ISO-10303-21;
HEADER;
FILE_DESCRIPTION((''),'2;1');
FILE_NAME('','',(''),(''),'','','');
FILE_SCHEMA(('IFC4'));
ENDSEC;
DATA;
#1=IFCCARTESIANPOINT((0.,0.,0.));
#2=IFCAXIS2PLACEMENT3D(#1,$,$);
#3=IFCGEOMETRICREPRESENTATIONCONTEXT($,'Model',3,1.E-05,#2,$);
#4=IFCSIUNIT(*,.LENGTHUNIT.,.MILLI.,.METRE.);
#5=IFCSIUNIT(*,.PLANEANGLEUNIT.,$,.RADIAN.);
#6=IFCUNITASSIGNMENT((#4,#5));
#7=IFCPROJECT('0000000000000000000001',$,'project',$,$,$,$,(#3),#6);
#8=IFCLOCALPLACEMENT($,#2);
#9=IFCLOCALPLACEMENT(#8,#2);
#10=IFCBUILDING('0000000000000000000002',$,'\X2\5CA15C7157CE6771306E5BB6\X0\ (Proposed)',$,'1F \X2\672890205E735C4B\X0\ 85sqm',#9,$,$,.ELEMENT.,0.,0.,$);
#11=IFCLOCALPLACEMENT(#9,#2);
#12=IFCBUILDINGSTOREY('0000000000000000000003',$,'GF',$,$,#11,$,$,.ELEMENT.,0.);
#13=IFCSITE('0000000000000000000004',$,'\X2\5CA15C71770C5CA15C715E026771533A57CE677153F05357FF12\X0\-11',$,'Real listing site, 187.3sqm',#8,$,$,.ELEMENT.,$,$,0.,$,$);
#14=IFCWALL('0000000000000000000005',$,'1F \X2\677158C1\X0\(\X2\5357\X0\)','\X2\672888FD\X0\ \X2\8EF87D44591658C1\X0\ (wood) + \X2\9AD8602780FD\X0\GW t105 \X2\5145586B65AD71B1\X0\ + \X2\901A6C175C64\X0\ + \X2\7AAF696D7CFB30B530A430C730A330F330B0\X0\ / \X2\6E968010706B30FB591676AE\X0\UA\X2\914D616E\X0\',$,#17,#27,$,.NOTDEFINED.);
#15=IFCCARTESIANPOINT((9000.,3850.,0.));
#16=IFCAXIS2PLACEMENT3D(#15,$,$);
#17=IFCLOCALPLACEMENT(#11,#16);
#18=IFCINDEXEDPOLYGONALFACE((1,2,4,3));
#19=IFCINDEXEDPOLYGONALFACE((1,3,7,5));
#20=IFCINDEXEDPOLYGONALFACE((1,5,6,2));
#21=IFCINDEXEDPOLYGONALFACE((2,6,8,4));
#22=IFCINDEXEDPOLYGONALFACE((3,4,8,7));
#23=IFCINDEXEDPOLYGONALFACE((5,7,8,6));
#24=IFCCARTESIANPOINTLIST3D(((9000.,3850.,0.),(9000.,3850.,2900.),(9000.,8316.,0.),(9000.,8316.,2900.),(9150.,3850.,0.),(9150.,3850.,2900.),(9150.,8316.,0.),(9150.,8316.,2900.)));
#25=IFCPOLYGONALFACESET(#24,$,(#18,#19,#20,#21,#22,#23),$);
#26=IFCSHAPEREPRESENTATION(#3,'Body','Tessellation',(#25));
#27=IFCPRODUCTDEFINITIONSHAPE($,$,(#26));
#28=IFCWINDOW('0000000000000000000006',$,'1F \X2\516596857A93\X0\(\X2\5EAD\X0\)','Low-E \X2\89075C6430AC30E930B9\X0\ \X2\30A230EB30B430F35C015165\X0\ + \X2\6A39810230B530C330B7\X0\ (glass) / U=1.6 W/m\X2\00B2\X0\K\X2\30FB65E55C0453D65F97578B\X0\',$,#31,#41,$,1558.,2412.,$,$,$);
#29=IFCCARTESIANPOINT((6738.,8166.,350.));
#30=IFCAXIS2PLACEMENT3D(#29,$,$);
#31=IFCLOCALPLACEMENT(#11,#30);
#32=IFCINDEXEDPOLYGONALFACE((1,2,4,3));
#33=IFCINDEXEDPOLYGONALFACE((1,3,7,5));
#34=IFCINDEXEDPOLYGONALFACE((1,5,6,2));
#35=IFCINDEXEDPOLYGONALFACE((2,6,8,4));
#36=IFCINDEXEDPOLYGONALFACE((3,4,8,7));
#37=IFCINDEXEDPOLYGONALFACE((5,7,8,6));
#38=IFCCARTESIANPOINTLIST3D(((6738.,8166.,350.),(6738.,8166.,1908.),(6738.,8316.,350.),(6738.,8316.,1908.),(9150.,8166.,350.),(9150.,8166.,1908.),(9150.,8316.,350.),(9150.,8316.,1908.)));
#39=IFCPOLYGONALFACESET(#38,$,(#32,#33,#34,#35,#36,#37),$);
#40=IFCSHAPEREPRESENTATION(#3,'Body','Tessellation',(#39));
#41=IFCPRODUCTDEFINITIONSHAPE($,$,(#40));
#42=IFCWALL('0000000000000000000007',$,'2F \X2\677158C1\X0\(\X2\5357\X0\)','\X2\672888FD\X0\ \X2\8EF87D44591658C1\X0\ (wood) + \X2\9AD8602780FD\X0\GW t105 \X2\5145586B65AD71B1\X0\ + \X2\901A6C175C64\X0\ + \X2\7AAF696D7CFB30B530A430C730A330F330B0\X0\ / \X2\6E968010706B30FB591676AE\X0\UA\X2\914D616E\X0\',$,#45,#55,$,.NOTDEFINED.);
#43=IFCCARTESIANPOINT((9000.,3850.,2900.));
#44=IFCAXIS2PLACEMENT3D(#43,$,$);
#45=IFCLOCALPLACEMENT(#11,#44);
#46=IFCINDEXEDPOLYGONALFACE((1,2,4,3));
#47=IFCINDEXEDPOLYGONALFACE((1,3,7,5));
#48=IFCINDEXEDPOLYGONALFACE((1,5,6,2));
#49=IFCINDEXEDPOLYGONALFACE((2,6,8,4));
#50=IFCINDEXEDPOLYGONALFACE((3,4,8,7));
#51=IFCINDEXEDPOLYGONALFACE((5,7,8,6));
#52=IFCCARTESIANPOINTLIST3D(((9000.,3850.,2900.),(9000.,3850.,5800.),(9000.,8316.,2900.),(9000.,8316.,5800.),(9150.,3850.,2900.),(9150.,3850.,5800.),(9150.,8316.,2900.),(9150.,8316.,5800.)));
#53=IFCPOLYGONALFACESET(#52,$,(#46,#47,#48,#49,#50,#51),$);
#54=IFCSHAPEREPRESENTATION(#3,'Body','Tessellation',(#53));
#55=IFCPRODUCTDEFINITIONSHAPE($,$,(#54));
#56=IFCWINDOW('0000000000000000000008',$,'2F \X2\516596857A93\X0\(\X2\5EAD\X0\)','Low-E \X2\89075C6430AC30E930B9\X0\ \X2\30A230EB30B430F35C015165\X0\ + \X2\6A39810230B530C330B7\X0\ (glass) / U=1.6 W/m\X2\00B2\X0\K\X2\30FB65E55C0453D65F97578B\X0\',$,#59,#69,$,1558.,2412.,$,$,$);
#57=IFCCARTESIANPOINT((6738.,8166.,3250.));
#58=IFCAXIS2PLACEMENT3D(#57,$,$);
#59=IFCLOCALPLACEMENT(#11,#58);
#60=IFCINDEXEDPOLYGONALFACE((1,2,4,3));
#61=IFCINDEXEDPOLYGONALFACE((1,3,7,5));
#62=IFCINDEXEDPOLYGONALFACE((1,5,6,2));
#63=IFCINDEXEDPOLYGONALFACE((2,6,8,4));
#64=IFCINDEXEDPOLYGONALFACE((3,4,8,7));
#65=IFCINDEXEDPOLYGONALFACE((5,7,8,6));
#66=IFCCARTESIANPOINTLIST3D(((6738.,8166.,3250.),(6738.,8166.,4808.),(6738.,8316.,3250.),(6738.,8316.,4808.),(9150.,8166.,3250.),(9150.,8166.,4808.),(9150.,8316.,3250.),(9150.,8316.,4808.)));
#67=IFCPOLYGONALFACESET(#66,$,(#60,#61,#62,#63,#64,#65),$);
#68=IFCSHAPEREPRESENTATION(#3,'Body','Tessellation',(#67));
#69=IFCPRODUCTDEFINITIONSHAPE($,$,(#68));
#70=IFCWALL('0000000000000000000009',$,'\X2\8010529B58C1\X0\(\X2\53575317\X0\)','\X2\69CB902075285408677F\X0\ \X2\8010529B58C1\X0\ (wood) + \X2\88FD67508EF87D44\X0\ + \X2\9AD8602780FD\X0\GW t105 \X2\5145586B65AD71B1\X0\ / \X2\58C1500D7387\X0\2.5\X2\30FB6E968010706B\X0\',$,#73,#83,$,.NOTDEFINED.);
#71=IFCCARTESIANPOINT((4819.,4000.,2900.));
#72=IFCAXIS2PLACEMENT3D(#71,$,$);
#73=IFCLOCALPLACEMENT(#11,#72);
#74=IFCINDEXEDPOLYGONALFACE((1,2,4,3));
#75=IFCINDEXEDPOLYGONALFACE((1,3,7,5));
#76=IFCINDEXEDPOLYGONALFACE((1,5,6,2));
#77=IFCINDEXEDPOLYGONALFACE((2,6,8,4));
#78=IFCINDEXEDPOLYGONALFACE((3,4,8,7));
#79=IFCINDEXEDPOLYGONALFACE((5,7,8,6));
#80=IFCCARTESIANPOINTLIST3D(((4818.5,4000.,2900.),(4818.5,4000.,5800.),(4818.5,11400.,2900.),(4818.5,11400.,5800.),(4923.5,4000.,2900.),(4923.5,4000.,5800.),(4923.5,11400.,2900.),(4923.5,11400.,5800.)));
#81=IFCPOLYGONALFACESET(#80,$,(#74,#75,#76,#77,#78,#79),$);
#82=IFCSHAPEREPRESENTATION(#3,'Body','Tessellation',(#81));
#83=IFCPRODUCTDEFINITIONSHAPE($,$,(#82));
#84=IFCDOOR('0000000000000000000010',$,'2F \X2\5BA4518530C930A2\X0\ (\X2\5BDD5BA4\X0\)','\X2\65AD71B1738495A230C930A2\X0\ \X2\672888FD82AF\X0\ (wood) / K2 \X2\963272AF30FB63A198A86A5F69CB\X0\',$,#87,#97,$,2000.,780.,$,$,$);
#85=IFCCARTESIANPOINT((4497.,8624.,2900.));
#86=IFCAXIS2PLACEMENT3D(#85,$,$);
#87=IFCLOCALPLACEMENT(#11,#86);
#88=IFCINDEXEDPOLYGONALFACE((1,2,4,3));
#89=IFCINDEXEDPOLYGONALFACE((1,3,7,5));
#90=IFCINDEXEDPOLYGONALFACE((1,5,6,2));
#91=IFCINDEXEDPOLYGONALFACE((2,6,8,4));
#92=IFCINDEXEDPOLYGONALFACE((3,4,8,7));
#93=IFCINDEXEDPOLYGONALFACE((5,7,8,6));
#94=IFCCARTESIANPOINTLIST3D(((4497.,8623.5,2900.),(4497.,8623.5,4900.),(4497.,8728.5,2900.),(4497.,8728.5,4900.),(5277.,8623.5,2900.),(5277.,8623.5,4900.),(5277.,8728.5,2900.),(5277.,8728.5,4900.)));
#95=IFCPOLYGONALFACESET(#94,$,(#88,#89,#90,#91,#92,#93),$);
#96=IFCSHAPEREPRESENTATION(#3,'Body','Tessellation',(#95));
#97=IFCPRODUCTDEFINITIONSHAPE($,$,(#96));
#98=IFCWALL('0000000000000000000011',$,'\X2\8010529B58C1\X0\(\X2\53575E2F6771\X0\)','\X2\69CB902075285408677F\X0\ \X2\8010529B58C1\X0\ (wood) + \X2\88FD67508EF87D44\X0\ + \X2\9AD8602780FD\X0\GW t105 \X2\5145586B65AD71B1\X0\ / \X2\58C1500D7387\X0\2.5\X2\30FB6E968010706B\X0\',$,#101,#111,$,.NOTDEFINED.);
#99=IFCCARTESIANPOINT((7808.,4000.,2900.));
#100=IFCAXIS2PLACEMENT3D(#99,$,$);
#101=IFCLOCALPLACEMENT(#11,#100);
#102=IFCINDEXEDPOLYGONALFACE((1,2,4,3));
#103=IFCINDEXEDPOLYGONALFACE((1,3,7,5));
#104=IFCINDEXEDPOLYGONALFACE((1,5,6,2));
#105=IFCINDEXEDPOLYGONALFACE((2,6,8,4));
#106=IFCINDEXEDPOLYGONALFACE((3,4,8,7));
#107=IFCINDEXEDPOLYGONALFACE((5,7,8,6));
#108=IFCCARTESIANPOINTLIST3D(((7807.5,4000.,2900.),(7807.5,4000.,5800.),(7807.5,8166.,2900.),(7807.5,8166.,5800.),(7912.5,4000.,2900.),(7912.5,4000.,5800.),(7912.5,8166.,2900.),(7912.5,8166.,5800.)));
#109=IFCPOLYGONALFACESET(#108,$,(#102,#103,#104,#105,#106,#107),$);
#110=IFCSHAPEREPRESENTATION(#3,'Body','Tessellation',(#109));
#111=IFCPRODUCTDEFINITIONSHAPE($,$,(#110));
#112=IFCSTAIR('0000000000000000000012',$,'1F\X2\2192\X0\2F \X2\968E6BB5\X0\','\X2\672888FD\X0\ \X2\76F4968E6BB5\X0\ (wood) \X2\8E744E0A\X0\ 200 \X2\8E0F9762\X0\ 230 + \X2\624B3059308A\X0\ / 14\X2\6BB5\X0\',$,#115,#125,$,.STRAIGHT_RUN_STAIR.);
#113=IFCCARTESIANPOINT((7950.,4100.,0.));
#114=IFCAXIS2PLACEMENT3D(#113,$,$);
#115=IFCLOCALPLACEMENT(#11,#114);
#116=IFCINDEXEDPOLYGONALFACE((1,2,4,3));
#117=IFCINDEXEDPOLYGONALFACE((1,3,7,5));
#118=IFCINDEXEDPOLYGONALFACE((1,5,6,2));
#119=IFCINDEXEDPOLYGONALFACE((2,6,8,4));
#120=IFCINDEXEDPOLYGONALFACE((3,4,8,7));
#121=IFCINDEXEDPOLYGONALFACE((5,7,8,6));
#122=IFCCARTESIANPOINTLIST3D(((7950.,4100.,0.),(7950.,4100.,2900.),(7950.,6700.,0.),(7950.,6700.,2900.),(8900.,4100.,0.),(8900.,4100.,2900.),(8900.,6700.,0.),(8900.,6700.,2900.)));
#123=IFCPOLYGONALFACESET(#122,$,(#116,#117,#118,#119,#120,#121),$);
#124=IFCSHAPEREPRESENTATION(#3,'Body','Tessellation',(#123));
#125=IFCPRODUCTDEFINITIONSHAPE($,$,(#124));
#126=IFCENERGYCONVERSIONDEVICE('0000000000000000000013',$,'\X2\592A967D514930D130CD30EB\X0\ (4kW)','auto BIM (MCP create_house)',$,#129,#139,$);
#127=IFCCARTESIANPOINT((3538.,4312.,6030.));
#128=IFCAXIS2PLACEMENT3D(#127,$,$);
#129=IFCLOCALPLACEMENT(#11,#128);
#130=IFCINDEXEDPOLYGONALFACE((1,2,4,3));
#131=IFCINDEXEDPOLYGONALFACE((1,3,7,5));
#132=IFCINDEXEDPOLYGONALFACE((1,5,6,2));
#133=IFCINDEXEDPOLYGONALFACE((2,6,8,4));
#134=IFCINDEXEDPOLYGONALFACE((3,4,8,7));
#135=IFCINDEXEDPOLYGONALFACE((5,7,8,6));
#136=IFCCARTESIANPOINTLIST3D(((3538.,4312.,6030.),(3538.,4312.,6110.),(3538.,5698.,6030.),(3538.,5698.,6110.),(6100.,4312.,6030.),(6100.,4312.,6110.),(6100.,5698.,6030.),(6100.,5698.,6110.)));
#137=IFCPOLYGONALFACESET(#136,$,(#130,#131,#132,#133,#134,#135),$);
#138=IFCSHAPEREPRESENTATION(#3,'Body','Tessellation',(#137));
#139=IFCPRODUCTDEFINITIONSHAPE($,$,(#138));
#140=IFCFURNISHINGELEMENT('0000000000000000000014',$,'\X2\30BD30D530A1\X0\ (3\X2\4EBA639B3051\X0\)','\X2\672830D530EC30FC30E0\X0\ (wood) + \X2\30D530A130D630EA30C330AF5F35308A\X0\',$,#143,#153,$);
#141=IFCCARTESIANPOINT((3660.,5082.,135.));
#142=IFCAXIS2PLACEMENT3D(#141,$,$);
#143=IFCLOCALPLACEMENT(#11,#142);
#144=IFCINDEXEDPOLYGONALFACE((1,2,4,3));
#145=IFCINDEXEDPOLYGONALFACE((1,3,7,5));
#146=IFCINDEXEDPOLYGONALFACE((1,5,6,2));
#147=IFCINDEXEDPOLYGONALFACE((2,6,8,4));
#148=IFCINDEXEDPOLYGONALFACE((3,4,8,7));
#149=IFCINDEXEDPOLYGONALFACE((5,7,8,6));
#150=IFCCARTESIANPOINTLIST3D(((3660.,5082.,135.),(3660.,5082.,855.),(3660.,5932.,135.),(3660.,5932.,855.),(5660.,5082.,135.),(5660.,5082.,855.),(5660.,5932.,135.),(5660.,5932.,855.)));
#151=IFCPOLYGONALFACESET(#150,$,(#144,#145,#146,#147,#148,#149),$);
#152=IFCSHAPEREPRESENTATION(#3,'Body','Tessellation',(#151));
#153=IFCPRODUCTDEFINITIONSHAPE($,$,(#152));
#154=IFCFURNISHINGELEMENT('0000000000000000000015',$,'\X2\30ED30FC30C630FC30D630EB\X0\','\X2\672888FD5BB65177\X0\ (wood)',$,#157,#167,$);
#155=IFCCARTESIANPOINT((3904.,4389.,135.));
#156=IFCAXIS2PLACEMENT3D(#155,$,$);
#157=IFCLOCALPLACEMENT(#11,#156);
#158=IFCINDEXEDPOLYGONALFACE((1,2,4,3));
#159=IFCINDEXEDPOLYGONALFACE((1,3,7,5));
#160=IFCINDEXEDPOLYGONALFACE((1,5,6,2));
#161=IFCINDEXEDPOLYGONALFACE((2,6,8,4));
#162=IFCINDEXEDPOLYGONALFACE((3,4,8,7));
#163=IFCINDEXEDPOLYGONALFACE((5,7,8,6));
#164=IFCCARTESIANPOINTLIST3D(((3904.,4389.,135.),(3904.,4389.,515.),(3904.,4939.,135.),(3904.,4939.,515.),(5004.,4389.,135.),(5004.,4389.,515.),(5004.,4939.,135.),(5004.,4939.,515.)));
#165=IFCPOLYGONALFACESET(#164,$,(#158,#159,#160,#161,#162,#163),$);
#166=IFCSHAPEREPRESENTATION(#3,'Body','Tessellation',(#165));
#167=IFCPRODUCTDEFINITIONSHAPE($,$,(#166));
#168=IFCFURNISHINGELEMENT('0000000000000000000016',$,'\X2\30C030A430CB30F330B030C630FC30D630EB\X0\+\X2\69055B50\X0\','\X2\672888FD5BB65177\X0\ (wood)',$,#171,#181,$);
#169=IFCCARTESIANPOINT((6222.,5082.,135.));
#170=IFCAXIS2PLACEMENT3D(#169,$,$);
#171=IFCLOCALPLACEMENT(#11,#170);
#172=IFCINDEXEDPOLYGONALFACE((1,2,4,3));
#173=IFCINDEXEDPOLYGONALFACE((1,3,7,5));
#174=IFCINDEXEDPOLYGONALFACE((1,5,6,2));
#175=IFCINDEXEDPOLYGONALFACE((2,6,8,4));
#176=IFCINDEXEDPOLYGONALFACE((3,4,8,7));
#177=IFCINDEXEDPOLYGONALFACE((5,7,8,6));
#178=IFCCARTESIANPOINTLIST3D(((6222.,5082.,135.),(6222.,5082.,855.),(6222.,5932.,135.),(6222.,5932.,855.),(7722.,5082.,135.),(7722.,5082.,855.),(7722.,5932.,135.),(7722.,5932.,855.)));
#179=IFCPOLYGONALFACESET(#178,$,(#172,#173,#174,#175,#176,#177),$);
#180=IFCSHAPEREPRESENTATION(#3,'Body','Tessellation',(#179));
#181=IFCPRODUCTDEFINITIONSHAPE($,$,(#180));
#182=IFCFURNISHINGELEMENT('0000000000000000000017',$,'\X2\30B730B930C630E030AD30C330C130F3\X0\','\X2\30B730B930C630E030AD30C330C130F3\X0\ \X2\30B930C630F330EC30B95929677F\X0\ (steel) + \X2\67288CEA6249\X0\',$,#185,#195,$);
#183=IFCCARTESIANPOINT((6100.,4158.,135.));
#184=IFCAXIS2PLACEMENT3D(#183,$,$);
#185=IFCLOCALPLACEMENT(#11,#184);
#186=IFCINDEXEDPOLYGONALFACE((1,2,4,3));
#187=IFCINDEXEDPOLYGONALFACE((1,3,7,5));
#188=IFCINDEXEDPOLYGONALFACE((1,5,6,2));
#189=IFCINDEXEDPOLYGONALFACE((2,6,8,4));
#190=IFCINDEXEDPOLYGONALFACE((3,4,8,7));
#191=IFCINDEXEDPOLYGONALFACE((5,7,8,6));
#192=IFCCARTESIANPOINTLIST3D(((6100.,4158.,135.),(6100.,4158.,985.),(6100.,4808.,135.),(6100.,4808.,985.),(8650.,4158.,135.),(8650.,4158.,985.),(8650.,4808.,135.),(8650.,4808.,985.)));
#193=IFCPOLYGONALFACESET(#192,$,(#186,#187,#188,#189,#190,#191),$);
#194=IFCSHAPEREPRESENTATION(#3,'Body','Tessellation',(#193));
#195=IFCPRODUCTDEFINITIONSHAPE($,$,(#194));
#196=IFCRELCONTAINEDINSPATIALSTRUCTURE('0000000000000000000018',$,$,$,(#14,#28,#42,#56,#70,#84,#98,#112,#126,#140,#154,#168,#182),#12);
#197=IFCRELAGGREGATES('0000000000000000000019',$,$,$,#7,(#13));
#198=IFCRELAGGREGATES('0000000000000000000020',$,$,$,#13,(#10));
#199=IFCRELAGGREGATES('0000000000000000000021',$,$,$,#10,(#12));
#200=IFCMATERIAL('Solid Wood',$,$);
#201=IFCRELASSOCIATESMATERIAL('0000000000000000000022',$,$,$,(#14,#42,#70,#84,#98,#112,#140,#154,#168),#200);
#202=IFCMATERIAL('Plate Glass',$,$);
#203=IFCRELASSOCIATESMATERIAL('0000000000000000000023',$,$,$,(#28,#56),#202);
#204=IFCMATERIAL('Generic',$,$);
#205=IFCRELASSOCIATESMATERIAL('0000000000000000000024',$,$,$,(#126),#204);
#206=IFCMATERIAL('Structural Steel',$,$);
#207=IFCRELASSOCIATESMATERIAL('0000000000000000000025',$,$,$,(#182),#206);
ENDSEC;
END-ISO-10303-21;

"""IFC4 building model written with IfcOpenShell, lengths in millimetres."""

from ifc_helpers import new_model, si_unit, frame, frame_2d, origin, place, context, project, spatial, rectangle, extrude, material, element, fill, save


model = new_model("IFC4")

# Units and contexts
model_context = context("Model", 3, precision=1e-05, world=origin())
ifc_project = project(units=[si_unit("LENGTHUNIT", "METRE", prefix="MILLI"), si_unit("PLANEANGLEUNIT", "RADIAN")], contexts=[model_context])

# Site, building, storey
site_placement = place(None, origin())
site = spatial("IfcSite", under=ifc_project, at=site_placement, Name="岡山県岡山市東区城東台南２-11", ObjectType="Real listing site, 187.3sqm", CompositionType="ELEMENT", RefElevation=0.0)
building_placement = place(site_placement, origin())
building = spatial("IfcBuilding", under=site, at=building_placement, Name="岡山城東の家 (Proposed)", ObjectType="1F 木造平屋 85sqm", CompositionType="ELEMENT", ElevationOfRefHeight=0.0, ElevationOfTerrain=0.0)
storey_placement = place(building_placement, origin())
storey = spatial("IfcBuildingStorey", under=building, at=storey_placement, Name="GF", CompositionType="ELEMENT", Elevation=0.0)

# Wall, opening, window
ifc_material_1 = material(Name="Solid Wood")
wall_1_placement = place(storey_placement, frame((9000.0, 3850.0, 0.0)))
wall_1 = element("IfcWall", 1, at=wall_1_placement, inside=storey, material=ifc_material_1, Name="1F 東壁(南)", Description="木製 軸組外壁 (wood) + 高性能GW t105 充填断熱 + 通気層 + 窯業系サイディング / 準耐火・外皮UA配慮", PredefinedType="NOTDEFINED", context=model_context, shape_type="SweptSolid", body=[
    extrude(rectangle(XDim=150.0, YDim=4466.0, at=frame_2d((75.0, 2233.0))), frame((9000.0, 3850.0, 0.0)), (0.0, 0.0, 1.0), 2900.0),
])
opening_1_placement = place(storey_placement, frame((6738.0, 8166.0, 350.0)))
opening_1 = element("IfcOpeningElement", 2, at=opening_1_placement, cuts=wall_1, PredefinedType="NOTDEFINED", context=model_context, shape_type="SweptSolid", body=[
    extrude(rectangle(XDim=2412.0, YDim=150.0, at=frame_2d((1206.0, 75.0))), frame((6738.0, 8166.0, 350.0)), (0.0, 0.0, 1.0), 1558.0),
])
ifc_material_2 = material(Name="Plate Glass")
window_1_placement = place(storey_placement, frame((6738.0, 8166.0, 350.0)))
window_1 = element("IfcWindow", 3, at=window_1_placement, inside=storey, material=ifc_material_2, Name="1F 入隅窓(庭)", Description="Low-E 複層ガラス アルゴン封入 + 樹脂サッシ (glass) / U=1.6 W/m²K・日射取得型", OverallHeight=1558.0, OverallWidth=2412.0, context=model_context, shape_type="SweptSolid", body=[
    extrude(rectangle(XDim=2412.0, YDim=150.0, at=frame_2d((1206.0, 75.0))), frame((6738.0, 8166.0, 350.0)), (0.0, 0.0, 1.0), 1558.0),
])
fill(opening_1, window_1)

# Wall, opening, window
wall_2_placement = place(storey_placement, frame((9000.0, 3850.0, 2900.0)))
wall_2 = element("IfcWall", 4, at=wall_2_placement, inside=storey, material=ifc_material_1, Name="2F 東壁(南)", Description="木製 軸組外壁 (wood) + 高性能GW t105 充填断熱 + 通気層 + 窯業系サイディング / 準耐火・外皮UA配慮", PredefinedType="NOTDEFINED", context=model_context, shape_type="SweptSolid", body=[
    extrude(rectangle(XDim=150.0, YDim=4466.0, at=frame_2d((75.0, 2233.0))), frame((9000.0, 3850.0, 2900.0)), (0.0, 0.0, 1.0), 2900.0),
])
opening_2_placement = place(storey_placement, frame((6738.0, 8166.0, 3250.0)))
opening_2 = element("IfcOpeningElement", 5, at=opening_2_placement, cuts=wall_2, PredefinedType="NOTDEFINED", context=model_context, shape_type="SweptSolid", body=[
    extrude(rectangle(XDim=2412.0, YDim=150.0, at=frame_2d((1206.0, 75.0))), frame((6738.0, 8166.0, 3250.0)), (0.0, 0.0, 1.0), 1558.0),
])
window_2_placement = place(storey_placement, frame((6738.0, 8166.0, 3250.0)))
window_2 = element("IfcWindow", 6, at=window_2_placement, inside=storey, material=ifc_material_2, Name="2F 入隅窓(庭)", Description="Low-E 複層ガラス アルゴン封入 + 樹脂サッシ (glass) / U=1.6 W/m²K・日射取得型", OverallHeight=1558.0, OverallWidth=2412.0, context=model_context, shape_type="SweptSolid", body=[
    extrude(rectangle(XDim=2412.0, YDim=150.0, at=frame_2d((1206.0, 75.0))), frame((6738.0, 8166.0, 3250.0)), (0.0, 0.0, 1.0), 1558.0),
])
fill(opening_2, window_2)

# Wall, opening, door
wall_3_placement = place(storey_placement, frame((4819.0, 4000.0, 2900.0)))
wall_3 = element("IfcWall", 7, at=wall_3_placement, inside=storey, material=ifc_material_1, Name="耐力壁(南北)", Description="構造用合板 耐力壁 (wood) + 製材軸組 + 高性能GW t105 充填断熱 / 壁倍率2.5・準耐火", PredefinedType="NOTDEFINED", context=model_context, shape_type="SweptSolid", body=[
    extrude(rectangle(XDim=105.0, YDim=7400.0, at=frame_2d((52.0, 3700.0))), frame((4819.0, 4000.0, 2900.0)), (0.0, 0.0, 1.0), 2900.0),
])
opening_3_placement = place(storey_placement, frame((4497.0, 8624.0, 2900.0)))
opening_3 = element("IfcOpeningElement", 8, at=opening_3_placement, cuts=wall_3, PredefinedType="NOTDEFINED", context=model_context, shape_type="SweptSolid", body=[
    extrude(rectangle(XDim=780.0, YDim=105.0, at=frame_2d((390.0, 52.0))), frame((4497.0, 8624.0, 2900.0)), (0.0, 0.0, 1.0), 2000.0),
])
door_1_placement = place(storey_placement, frame((4497.0, 8624.0, 2900.0)))
door_1 = element("IfcDoor", 9, at=door_1_placement, inside=storey, material=ifc_material_1, Name="2F 室内ドア (寝室)", Description="断熱玄関ドア 木製芯 (wood) / K2 防犯・採風機構", OverallHeight=2000.0, OverallWidth=780.0, context=model_context, shape_type="SweptSolid", body=[
    extrude(rectangle(XDim=780.0, YDim=105.0, at=frame_2d((390.0, 52.0))), frame((4497.0, 8624.0, 2900.0)), (0.0, 0.0, 1.0), 2000.0),
])
fill(opening_3, door_1)

# Wall
wall_4_placement = place(storey_placement, frame((7808.0, 4000.0, 2900.0)))
element("IfcWall", 10, at=wall_4_placement, inside=storey, material=ifc_material_1, Name="耐力壁(南帯東)", Description="構造用合板 耐力壁 (wood) + 製材軸組 + 高性能GW t105 充填断熱 / 壁倍率2.5・準耐火", PredefinedType="NOTDEFINED", context=model_context, shape_type="SweptSolid", body=[
    extrude(rectangle(XDim=105.0, YDim=4166.0, at=frame_2d((52.0, 2083.0))), frame((7808.0, 4000.0, 2900.0)), (0.0, 0.0, 1.0), 2900.0),
])

# Stair
stair_placement = place(storey_placement, frame((7950.0, 4100.0, 0.0)))
element("IfcStair", 11, at=stair_placement, inside=storey, material=ifc_material_1, Name="1F→2F 階段", Description="木製 直階段 (wood) 蹴上 200 踏面 230 + 手すり / 14段", PredefinedType="STRAIGHT_RUN_STAIR", context=model_context, shape_type="SweptSolid", body=[
    extrude(rectangle(XDim=950.0, YDim=2600.0, at=frame_2d((475.0, 1300.0))), frame((7950.0, 4100.0, 0.0)), (0.0, 0.0, 1.0), 2900.0),
])

# Energy conversion device
ifc_material_3 = material(Name="Generic")
energy_conversion_device_placement = place(storey_placement, frame((3538.0, 4312.0, 6030.0)))
element("IfcEnergyConversionDevice", 12, at=energy_conversion_device_placement, inside=storey, material=ifc_material_3, Name="太陽光パネル (4kW)", Description="auto BIM (MCP create_house)", context=model_context, shape_type="SweptSolid", body=[
    extrude(rectangle(XDim=2562.0, YDim=1386.0, at=frame_2d((1281.0, 693.0))), frame((3538.0, 4312.0, 6030.0)), (0.0, 0.0, 1.0), 80.0),
])

# Furnishing elements
furnishing_1_placement = place(storey_placement, frame((3660.0, 5082.0, 135.0)))
element("IfcFurnishingElement", 13, at=furnishing_1_placement, inside=storey, material=ifc_material_1, Name="ソファ (3人掛け)", Description="木フレーム (wood) + ファブリック張り", context=model_context, shape_type="SweptSolid", body=[
    extrude(rectangle(XDim=2000.0, YDim=850.0, at=frame_2d((1000.0, 425.0))), frame((3660.0, 5082.0, 135.0)), (0.0, 0.0, 1.0), 720.0),
])
furnishing_2_placement = place(storey_placement, frame((3904.0, 4389.0, 135.0)))
element("IfcFurnishingElement", 14, at=furnishing_2_placement, inside=storey, material=ifc_material_1, Name="ローテーブル", Description="木製家具 (wood)", context=model_context, shape_type="SweptSolid", body=[
    extrude(rectangle(XDim=1100.0, YDim=550.0, at=frame_2d((550.0, 275.0))), frame((3904.0, 4389.0, 135.0)), (0.0, 0.0, 1.0), 380.0),
])
furnishing_3_placement = place(storey_placement, frame((6222.0, 5082.0, 135.0)))
element("IfcFurnishingElement", 15, at=furnishing_3_placement, inside=storey, material=ifc_material_1, Name="ダイニングテーブル+椅子", Description="木製家具 (wood)", context=model_context, shape_type="SweptSolid", body=[
    extrude(rectangle(XDim=1500.0, YDim=850.0, at=frame_2d((750.0, 425.0))), frame((6222.0, 5082.0, 135.0)), (0.0, 0.0, 1.0), 720.0),
])
ifc_material_4 = material(Name="Structural Steel")
furnishing_4_placement = place(storey_placement, frame((6100.0, 4158.0, 135.0)))
element("IfcFurnishingElement", 16, at=furnishing_4_placement, inside=storey, material=ifc_material_4, Name="システムキッチン", Description="システムキッチン ステンレス天板 (steel) + 木質扉", context=model_context, shape_type="SweptSolid", body=[
    extrude(rectangle(XDim=2550.0, YDim=650.0, at=frame_2d((1275.0, 325.0))), frame((6100.0, 4158.0, 135.0)), (0.0, 0.0, 1.0), 850.0),
])

save(model, "model.ifc")
